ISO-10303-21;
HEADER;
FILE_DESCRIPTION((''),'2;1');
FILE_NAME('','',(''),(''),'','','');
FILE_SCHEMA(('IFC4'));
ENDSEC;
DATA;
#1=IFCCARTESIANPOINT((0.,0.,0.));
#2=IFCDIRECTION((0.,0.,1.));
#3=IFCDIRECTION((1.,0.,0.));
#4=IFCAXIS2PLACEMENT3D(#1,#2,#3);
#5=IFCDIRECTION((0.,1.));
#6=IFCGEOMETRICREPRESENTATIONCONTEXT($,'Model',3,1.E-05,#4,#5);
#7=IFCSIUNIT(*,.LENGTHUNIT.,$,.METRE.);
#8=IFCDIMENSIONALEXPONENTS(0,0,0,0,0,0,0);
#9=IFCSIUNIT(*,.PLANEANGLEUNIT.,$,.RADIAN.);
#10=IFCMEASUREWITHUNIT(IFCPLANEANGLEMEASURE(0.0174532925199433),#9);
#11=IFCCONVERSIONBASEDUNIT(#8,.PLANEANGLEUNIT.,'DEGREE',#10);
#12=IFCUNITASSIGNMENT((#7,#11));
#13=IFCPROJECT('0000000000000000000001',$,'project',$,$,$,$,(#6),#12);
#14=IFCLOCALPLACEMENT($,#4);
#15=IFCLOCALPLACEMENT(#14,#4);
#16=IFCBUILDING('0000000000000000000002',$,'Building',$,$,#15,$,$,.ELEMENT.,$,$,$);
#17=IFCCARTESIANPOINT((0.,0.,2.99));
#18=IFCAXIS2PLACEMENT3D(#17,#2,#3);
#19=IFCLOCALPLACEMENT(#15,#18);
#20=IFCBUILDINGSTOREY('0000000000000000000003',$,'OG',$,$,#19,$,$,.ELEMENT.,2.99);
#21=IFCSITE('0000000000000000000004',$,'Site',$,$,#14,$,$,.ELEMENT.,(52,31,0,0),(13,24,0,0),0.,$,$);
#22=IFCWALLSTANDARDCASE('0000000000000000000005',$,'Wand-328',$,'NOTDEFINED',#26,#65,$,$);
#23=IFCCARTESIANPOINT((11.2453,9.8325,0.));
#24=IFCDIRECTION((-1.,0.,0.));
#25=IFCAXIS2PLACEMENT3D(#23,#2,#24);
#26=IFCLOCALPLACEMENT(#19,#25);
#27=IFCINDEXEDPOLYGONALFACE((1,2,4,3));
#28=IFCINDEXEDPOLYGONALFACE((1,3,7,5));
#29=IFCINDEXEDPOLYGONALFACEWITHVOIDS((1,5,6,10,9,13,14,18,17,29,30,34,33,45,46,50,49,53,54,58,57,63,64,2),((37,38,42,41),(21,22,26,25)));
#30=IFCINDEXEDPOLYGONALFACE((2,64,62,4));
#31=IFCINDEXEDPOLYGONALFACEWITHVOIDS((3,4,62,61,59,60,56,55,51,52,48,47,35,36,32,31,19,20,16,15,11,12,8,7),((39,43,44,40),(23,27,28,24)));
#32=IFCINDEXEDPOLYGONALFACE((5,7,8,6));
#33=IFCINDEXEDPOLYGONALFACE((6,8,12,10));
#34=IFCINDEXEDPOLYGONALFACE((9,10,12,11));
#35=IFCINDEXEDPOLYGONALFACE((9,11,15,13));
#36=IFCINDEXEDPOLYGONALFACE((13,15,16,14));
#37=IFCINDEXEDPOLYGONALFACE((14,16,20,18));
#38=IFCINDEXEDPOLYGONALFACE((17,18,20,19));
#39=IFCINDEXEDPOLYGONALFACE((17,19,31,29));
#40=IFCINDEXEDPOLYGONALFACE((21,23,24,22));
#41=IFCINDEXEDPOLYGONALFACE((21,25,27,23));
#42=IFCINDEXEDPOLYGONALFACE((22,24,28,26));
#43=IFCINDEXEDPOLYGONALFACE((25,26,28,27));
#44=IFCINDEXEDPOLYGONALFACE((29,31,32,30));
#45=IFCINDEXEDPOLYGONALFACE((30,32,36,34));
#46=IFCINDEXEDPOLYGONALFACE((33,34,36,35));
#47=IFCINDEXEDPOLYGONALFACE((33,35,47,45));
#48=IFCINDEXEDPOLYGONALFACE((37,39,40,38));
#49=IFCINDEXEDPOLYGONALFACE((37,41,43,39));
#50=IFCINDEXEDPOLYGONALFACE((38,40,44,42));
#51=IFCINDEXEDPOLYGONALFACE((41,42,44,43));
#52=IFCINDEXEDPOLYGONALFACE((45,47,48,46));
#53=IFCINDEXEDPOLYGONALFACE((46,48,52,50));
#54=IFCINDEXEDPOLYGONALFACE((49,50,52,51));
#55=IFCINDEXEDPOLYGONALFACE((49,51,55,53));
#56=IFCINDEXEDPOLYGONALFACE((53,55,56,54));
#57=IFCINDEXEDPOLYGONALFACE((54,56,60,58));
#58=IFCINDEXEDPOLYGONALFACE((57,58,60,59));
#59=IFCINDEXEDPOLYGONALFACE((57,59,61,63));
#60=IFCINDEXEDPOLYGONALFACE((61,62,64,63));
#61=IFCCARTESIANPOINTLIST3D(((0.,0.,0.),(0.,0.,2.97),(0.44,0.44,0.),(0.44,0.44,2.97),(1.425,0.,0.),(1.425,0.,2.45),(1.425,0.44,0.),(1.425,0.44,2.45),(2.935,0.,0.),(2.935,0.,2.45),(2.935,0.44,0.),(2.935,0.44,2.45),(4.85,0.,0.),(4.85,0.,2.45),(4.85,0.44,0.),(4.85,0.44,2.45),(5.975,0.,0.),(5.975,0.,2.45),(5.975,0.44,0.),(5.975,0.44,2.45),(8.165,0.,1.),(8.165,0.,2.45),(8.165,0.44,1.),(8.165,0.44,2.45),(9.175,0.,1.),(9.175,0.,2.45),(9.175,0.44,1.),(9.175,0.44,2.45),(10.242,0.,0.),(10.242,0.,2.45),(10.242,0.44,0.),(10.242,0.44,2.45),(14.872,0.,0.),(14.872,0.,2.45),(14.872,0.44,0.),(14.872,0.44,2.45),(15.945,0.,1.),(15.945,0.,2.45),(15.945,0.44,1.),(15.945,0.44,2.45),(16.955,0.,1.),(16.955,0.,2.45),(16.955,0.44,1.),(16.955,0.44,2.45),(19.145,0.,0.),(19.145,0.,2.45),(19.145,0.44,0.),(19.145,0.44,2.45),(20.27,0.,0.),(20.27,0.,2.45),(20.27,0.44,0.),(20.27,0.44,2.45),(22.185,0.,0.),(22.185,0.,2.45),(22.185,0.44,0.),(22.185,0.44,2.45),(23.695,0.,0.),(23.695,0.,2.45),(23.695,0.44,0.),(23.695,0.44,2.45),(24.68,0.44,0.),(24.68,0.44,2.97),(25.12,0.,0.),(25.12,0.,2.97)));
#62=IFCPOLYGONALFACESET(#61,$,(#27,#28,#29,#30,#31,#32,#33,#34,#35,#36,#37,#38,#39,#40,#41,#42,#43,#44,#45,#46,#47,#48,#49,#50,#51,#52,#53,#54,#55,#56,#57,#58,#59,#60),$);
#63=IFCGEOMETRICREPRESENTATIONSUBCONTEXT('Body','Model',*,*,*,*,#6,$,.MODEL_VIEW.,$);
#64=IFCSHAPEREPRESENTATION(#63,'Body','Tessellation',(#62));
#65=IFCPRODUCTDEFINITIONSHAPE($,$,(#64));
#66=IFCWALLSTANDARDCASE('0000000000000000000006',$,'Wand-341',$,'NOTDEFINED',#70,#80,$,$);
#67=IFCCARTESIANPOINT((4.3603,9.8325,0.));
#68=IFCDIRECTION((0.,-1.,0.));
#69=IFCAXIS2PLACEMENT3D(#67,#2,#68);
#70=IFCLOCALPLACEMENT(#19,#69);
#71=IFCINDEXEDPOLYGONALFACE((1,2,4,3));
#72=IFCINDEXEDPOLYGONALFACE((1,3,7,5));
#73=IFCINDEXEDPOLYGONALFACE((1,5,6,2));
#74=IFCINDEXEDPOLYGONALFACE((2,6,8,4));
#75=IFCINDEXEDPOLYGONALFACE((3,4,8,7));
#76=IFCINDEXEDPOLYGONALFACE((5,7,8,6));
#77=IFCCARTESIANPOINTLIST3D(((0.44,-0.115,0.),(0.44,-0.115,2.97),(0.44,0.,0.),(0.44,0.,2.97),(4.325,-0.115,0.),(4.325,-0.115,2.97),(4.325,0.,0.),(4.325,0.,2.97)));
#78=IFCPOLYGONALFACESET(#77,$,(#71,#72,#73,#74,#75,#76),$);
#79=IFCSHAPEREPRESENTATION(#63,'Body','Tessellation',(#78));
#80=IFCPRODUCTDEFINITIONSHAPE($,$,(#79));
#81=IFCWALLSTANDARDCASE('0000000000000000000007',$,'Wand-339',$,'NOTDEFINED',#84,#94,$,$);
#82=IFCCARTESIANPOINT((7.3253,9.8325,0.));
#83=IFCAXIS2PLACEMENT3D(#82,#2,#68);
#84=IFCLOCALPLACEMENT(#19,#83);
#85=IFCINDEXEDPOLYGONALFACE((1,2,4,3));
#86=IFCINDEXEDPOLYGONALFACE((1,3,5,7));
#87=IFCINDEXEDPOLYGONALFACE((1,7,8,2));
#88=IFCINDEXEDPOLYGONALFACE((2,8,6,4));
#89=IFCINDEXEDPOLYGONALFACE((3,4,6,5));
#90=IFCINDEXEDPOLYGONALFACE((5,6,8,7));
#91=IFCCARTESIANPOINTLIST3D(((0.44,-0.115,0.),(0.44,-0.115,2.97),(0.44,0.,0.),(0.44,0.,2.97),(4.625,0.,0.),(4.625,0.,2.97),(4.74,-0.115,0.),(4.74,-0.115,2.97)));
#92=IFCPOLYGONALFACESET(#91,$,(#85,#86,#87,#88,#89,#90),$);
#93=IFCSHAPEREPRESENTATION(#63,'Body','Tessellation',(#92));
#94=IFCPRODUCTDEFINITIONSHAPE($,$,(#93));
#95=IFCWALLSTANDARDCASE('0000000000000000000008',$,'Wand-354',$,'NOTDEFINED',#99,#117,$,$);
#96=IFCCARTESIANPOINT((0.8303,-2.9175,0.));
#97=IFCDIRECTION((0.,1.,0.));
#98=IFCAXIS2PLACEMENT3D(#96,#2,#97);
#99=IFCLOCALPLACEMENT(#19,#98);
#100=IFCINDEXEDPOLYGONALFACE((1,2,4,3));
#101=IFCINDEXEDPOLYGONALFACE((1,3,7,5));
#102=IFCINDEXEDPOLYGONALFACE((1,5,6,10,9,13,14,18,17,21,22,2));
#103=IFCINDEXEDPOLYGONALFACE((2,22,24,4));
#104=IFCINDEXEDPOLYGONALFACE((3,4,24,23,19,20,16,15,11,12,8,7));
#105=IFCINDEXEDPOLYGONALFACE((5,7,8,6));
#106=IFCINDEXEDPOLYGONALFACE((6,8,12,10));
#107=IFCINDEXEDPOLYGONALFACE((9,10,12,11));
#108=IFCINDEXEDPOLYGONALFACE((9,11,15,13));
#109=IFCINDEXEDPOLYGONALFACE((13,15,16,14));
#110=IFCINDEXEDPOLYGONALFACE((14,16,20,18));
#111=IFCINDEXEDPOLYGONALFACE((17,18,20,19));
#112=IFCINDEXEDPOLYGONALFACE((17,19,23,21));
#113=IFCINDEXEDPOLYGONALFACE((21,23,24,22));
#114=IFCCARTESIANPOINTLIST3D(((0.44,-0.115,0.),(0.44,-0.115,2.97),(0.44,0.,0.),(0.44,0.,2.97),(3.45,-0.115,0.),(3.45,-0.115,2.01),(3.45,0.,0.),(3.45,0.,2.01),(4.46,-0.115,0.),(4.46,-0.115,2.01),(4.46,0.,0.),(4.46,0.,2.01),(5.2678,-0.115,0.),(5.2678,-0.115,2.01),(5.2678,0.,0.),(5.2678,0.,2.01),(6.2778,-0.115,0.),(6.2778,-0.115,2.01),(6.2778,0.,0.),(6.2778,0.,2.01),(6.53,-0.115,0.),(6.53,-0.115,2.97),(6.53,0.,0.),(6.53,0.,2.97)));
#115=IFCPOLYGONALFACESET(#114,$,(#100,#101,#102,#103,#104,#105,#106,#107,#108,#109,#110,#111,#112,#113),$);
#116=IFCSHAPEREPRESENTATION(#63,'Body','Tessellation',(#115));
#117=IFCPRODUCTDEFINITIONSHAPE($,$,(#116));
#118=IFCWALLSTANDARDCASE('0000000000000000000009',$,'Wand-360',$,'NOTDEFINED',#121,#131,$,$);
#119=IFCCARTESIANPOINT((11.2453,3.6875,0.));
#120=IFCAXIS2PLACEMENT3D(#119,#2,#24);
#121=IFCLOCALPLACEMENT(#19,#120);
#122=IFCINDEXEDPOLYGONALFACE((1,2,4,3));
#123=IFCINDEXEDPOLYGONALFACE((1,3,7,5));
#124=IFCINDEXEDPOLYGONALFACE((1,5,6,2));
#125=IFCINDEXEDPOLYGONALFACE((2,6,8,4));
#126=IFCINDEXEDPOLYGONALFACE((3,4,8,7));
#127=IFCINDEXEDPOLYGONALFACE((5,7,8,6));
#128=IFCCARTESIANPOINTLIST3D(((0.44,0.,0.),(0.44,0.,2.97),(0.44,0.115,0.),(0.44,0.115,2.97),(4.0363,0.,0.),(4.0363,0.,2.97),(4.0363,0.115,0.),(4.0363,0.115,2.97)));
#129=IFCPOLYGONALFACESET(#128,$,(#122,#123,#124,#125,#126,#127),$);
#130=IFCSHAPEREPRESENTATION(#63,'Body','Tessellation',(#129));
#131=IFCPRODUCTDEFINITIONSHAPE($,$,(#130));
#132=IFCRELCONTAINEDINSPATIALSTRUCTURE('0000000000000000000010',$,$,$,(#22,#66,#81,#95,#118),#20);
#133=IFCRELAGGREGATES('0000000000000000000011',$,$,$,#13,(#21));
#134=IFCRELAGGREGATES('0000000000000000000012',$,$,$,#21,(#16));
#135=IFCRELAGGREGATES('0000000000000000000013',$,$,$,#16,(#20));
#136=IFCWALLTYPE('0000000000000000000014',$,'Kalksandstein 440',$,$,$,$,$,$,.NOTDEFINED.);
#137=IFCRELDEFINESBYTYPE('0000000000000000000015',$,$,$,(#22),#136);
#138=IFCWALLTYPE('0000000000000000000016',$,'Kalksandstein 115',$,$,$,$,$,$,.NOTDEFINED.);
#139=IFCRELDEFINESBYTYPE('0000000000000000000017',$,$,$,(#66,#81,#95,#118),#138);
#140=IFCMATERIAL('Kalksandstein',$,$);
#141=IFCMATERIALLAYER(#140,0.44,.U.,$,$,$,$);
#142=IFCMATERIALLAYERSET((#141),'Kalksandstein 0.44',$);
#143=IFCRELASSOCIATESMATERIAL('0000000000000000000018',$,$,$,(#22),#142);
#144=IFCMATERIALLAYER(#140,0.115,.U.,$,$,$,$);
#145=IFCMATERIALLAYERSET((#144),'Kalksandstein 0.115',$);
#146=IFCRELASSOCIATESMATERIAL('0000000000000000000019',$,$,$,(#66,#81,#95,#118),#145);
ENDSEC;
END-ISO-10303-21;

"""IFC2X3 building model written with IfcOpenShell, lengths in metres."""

from ifc_helpers import new_model, entity, si_unit, converted_unit, direction, frame, origin_with_axes, origin_2d_with_axis, place, context, subcontext, project, spatial, polyline, rectangle, outline, extrude, material, layer, layer_set, layer_usage, type_object, element, save


model = new_model("IFC2X3")

# Units and contexts
model_context = context("Model", 3, precision=1e-05, world=origin_with_axes(), true_north=direction((0.0, 1.0)))
body_context = subcontext(model_context, "Body", "Model", "MODEL_VIEW")
ifc_project = project(units=[si_unit("LENGTHUNIT", "METRE"), converted_unit("PLANEANGLEUNIT", "DEGREE", entity("IfcPlaneAngleMeasure", 0.0174532925199433), si_unit("PLANEANGLEUNIT", "RADIAN"), dimensions=[0, 0, 0, 0, 0, 0, 0])], contexts=[model_context])

# Site, building, storey
site_placement = place(None, origin_with_axes())
site = spatial("IfcSite", under=ifc_project, at=site_placement, Name="Site", CompositionType="ELEMENT", RefLatitude=(52, 31, 0, 0), RefLongitude=(13, 24, 0, 0), RefElevation=0.0)
building_placement = place(site_placement, origin_with_axes())
building = spatial("IfcBuilding", under=site, at=building_placement, Name="Building", CompositionType="ELEMENT")
storey_placement = place(building_placement, frame((0.0, 0.0, 2.99), z_axis=(0.0, 0.0, 1.0), x_axis=(1.0, 0.0, 0.0)))
storey = spatial("IfcBuildingStorey", under=building, at=storey_placement, Name="OG", CompositionType="ELEMENT", Elevation=2.99)

# Wall, openings
ifc_material = material(Name="Kalksandstein")
ifc_layer_1 = layer(ifc_material, 0.44, ventilated="UNKNOWN")
ifc_layer_set_1 = layer_set([ifc_layer_1], Name="Kalksandstein 0.44")
ifc_layer_usage_1 = layer_usage(ifc_layer_set_1, "AXIS2", "NEGATIVE", 0.44)
wall_type_1 = type_object("IfcWallType", Name="Kalksandstein 440", PredefinedType="NOTDEFINED")
wall_1_placement = place(storey_placement, frame((11.2453, 9.8325, 0.0), z_axis=(0.0, 0.0, 1.0), x_axis=(-1.0, 0.0, 0.0)))
wall_1 = element("IfcWallStandardCase", 1, at=wall_1_placement, inside=storey, type_object=wall_type_1, material=ifc_layer_usage_1, Name="Wand-328", ObjectType="NOTDEFINED", context=body_context, shape_type="SweptSolid", body=[
    extrude(outline(polyline([(0.0, 0.0), (25.12, 0.0), (24.68, 0.44), (0.44, 0.44), (0.0, 0.0)])), origin_with_axes(), (0.0, 0.0, 1.0), 2.97),
])
opening_1_placement = place(wall_1_placement, frame((2.18, 0.0, 0.0), z_axis=(0.0, 0.0, 1.0), x_axis=(1.0, 0.0, 0.0)))
element("IfcOpeningElement", 2, at=opening_1_placement, cuts=wall_1, context=body_context, shape_type="SweptSolid", body=[
    extrude(rectangle(XDim=1.51, YDim=2.45, at=origin_2d_with_axis()), frame((0.0, 0.44, 1.225), z_axis=(0.0, -1.0, 0.0), x_axis=(-1.0, 0.0, 0.0)), (0.0, 0.0, 1.0), 1.32),
])
opening_2_placement = place(wall_1_placement, frame((5.4125, 0.0, 0.0), z_axis=(0.0, 0.0, 1.0), x_axis=(1.0, 0.0, 0.0)))
element("IfcOpeningElement", 3, at=opening_2_placement, cuts=wall_1, context=body_context, shape_type="SweptSolid", body=[
    extrude(rectangle(XDim=1.125, YDim=2.45, at=origin_2d_with_axis()), frame((0.0, 0.44, 1.225), z_axis=(0.0, -1.0, 0.0), x_axis=(-1.0, 0.0, 0.0)), (0.0, 0.0, 1.0), 1.32),
])
opening_3_placement = place(wall_1_placement, frame((19.7075, 0.0, 0.0), z_axis=(0.0, 0.0, 1.0), x_axis=(1.0, 0.0, 0.0)))
element("IfcOpeningElement", 4, at=opening_3_placement, cuts=wall_1, context=body_context, shape_type="SweptSolid", body=[
    extrude(rectangle(XDim=1.125, YDim=2.45, at=origin_2d_with_axis()), frame((0.0, 0.44, 1.225), z_axis=(0.0, -1.0, 0.0), x_axis=(-1.0, 0.0, 0.0)), (0.0, 0.0, 1.0), 1.32),
])
opening_4_placement = place(wall_1_placement, frame((22.94, 0.0, 0.0), z_axis=(0.0, 0.0, 1.0), x_axis=(1.0, 0.0, 0.0)))
element("IfcOpeningElement", 5, at=opening_4_placement, cuts=wall_1, context=body_context, shape_type="SweptSolid", body=[
    extrude(rectangle(XDim=1.51, YDim=2.45, at=origin_2d_with_axis()), frame((0.0, 0.44, 1.225), z_axis=(0.0, -1.0, 0.0), x_axis=(-1.0, 0.0, 0.0)), (0.0, 0.0, 1.0), 1.32),
])
opening_5_placement = place(wall_1_placement, frame((12.557, 0.0, 0.0), z_axis=(0.0, 0.0, 1.0), x_axis=(1.0, 0.0, 0.0)))
element("IfcOpeningElement", 6, at=opening_5_placement, cuts=wall_1, context=body_context, shape_type="SweptSolid", body=[
    extrude(rectangle(XDim=4.63, YDim=2.45, at=origin_2d_with_axis()), frame((0.0, 0.44, 1.225), z_axis=(0.0, -1.0, 0.0), x_axis=(-1.0, 0.0, 0.0)), (0.0, 0.0, 1.0), 1.32),
])
opening_6_placement = place(wall_1_placement, frame((16.45, 0.0, 1.0), z_axis=(0.0, 0.0, 1.0), x_axis=(1.0, 0.0, 0.0)))
element("IfcOpeningElement", 7, at=opening_6_placement, cuts=wall_1, context=body_context, shape_type="SweptSolid", body=[
    extrude(rectangle(XDim=1.01, YDim=1.45, at=origin_2d_with_axis()), frame((0.0, 0.44, 0.725), z_axis=(0.0, -1.0, 0.0), x_axis=(-1.0, 0.0, 0.0)), (0.0, 0.0, 1.0), 1.32),
])
opening_7_placement = place(wall_1_placement, frame((8.67, 0.0, 1.0), z_axis=(0.0, 0.0, 1.0), x_axis=(1.0, 0.0, 0.0)))
element("IfcOpeningElement", 8, at=opening_7_placement, cuts=wall_1, context=body_context, shape_type="SweptSolid", body=[
    extrude(rectangle(XDim=1.01, YDim=1.45, at=origin_2d_with_axis()), frame((0.0, 0.44, 0.725), z_axis=(0.0, -1.0, 0.0), x_axis=(-1.0, 0.0, 0.0)), (0.0, 0.0, 1.0), 1.32),
])

# Shared definitions
ifc_layer_2 = layer(ifc_material, 0.115, ventilated="UNKNOWN")
ifc_layer_set_2 = layer_set([ifc_layer_2], Name="Kalksandstein 0.115")
wall_type_2 = type_object("IfcWallType", Name="Kalksandstein 115", PredefinedType="NOTDEFINED")

# Walls
ifc_layer_usage_2 = layer_usage(ifc_layer_set_2, "AXIS2", "POSITIVE", -0.115)
wall_2_placement = place(storey_placement, frame((4.3603, 9.8325, 0.0), z_axis=(0.0, 0.0, 1.0), x_axis=(0.0, -1.0, 0.0)))
element("IfcWallStandardCase", 9, at=wall_2_placement, inside=storey, type_object=wall_type_2, material=ifc_layer_usage_2, Name="Wand-341", ObjectType="NOTDEFINED", context=body_context, shape_type="SweptSolid", body=[
    extrude(outline(polyline([(0.44, -0.115), (4.325, -0.115), (4.325, 0.0), (0.44, 0.0), (0.44, -0.115)])), origin_with_axes(), (0.0, 0.0, 1.0), 2.97),
])
ifc_layer_usage_3 = layer_usage(ifc_layer_set_2, "AXIS2", "POSITIVE", -0.115)
wall_3_placement = place(storey_placement, frame((7.3253, 9.8325, 0.0), z_axis=(0.0, 0.0, 1.0), x_axis=(0.0, -1.0, 0.0)))
element("IfcWallStandardCase", 10, at=wall_3_placement, inside=storey, type_object=wall_type_2, material=ifc_layer_usage_3, Name="Wand-339", ObjectType="NOTDEFINED", context=body_context, shape_type="SweptSolid", body=[
    extrude(outline(polyline([(0.44, -0.115), (4.74, -0.115), (4.625, 0.0), (0.44, 0.0), (0.44, -0.115)])), origin_with_axes(), (0.0, 0.0, 1.0), 2.97),
])

# Wall, openings
ifc_layer_usage_4 = layer_usage(ifc_layer_set_2, "AXIS2", "POSITIVE", -0.115)
wall_4_placement = place(storey_placement, frame((0.8303, -2.9175, 0.0), z_axis=(0.0, 0.0, 1.0), x_axis=(0.0, 1.0, 0.0)))
wall_4 = element("IfcWallStandardCase", 11, at=wall_4_placement, inside=storey, type_object=wall_type_2, material=ifc_layer_usage_4, Name="Wand-354", ObjectType="NOTDEFINED", context=body_context, shape_type="SweptSolid", body=[
    extrude(outline(polyline([(0.44, -0.115), (6.53, -0.115), (6.53, 0.0), (0.44, 0.0), (0.44, -0.115)])), origin_with_axes(), (0.0, 0.0, 1.0), 2.97),
])
opening_8_placement = place(wall_4_placement, frame((3.955, 0.0, 0.0), z_axis=(0.0, 0.0, 1.0), x_axis=(1.0, 0.0, 0.0)))
element("IfcOpeningElement", 12, at=opening_8_placement, cuts=wall_4, context=body_context, shape_type="SweptSolid", body=[
    extrude(rectangle(XDim=1.01, YDim=2.01, at=origin_2d_with_axis()), frame((0.0, 0.115, 1.005), z_axis=(0.0, 1.0, 0.0), x_axis=(1.0, 0.0, 0.0)), (0.0, 0.0, -1.0), 0.345),
])
opening_9_placement = place(wall_4_placement, frame((5.7728, 0.0, 0.0), z_axis=(0.0, 0.0, 1.0), x_axis=(1.0, 0.0, 0.0)))
element("IfcOpeningElement", 13, at=opening_9_placement, cuts=wall_4, context=body_context, shape_type="SweptSolid", body=[
    extrude(rectangle(XDim=1.01, YDim=2.01, at=origin_2d_with_axis()), frame((0.0, -0.115, 1.005), z_axis=(0.0, 1.0, 0.0), x_axis=(1.0, 0.0, 0.0)), (0.0, 0.0, 1.0), 0.345),
])

# Wall
ifc_layer_usage_5 = layer_usage(ifc_layer_set_2, "AXIS2", "NEGATIVE", 0.115)
wall_5_placement = place(storey_placement, frame((11.2453, 3.6875, 0.0), z_axis=(0.0, 0.0, 1.0), x_axis=(-1.0, 0.0, 0.0)))
element("IfcWallStandardCase", 14, at=wall_5_placement, inside=storey, type_object=wall_type_2, material=ifc_layer_usage_5, Name="Wand-360", ObjectType="NOTDEFINED", context=body_context, shape_type="SweptSolid", body=[
    extrude(outline(polyline([(0.44, 0.0), (4.0363, 0.0), (4.0363, 0.115), (0.44, 0.115), (0.44, 0.0)])), origin_with_axes(), (0.0, 0.0, 1.0), 2.97),
])

save(model, "model.ifc")
